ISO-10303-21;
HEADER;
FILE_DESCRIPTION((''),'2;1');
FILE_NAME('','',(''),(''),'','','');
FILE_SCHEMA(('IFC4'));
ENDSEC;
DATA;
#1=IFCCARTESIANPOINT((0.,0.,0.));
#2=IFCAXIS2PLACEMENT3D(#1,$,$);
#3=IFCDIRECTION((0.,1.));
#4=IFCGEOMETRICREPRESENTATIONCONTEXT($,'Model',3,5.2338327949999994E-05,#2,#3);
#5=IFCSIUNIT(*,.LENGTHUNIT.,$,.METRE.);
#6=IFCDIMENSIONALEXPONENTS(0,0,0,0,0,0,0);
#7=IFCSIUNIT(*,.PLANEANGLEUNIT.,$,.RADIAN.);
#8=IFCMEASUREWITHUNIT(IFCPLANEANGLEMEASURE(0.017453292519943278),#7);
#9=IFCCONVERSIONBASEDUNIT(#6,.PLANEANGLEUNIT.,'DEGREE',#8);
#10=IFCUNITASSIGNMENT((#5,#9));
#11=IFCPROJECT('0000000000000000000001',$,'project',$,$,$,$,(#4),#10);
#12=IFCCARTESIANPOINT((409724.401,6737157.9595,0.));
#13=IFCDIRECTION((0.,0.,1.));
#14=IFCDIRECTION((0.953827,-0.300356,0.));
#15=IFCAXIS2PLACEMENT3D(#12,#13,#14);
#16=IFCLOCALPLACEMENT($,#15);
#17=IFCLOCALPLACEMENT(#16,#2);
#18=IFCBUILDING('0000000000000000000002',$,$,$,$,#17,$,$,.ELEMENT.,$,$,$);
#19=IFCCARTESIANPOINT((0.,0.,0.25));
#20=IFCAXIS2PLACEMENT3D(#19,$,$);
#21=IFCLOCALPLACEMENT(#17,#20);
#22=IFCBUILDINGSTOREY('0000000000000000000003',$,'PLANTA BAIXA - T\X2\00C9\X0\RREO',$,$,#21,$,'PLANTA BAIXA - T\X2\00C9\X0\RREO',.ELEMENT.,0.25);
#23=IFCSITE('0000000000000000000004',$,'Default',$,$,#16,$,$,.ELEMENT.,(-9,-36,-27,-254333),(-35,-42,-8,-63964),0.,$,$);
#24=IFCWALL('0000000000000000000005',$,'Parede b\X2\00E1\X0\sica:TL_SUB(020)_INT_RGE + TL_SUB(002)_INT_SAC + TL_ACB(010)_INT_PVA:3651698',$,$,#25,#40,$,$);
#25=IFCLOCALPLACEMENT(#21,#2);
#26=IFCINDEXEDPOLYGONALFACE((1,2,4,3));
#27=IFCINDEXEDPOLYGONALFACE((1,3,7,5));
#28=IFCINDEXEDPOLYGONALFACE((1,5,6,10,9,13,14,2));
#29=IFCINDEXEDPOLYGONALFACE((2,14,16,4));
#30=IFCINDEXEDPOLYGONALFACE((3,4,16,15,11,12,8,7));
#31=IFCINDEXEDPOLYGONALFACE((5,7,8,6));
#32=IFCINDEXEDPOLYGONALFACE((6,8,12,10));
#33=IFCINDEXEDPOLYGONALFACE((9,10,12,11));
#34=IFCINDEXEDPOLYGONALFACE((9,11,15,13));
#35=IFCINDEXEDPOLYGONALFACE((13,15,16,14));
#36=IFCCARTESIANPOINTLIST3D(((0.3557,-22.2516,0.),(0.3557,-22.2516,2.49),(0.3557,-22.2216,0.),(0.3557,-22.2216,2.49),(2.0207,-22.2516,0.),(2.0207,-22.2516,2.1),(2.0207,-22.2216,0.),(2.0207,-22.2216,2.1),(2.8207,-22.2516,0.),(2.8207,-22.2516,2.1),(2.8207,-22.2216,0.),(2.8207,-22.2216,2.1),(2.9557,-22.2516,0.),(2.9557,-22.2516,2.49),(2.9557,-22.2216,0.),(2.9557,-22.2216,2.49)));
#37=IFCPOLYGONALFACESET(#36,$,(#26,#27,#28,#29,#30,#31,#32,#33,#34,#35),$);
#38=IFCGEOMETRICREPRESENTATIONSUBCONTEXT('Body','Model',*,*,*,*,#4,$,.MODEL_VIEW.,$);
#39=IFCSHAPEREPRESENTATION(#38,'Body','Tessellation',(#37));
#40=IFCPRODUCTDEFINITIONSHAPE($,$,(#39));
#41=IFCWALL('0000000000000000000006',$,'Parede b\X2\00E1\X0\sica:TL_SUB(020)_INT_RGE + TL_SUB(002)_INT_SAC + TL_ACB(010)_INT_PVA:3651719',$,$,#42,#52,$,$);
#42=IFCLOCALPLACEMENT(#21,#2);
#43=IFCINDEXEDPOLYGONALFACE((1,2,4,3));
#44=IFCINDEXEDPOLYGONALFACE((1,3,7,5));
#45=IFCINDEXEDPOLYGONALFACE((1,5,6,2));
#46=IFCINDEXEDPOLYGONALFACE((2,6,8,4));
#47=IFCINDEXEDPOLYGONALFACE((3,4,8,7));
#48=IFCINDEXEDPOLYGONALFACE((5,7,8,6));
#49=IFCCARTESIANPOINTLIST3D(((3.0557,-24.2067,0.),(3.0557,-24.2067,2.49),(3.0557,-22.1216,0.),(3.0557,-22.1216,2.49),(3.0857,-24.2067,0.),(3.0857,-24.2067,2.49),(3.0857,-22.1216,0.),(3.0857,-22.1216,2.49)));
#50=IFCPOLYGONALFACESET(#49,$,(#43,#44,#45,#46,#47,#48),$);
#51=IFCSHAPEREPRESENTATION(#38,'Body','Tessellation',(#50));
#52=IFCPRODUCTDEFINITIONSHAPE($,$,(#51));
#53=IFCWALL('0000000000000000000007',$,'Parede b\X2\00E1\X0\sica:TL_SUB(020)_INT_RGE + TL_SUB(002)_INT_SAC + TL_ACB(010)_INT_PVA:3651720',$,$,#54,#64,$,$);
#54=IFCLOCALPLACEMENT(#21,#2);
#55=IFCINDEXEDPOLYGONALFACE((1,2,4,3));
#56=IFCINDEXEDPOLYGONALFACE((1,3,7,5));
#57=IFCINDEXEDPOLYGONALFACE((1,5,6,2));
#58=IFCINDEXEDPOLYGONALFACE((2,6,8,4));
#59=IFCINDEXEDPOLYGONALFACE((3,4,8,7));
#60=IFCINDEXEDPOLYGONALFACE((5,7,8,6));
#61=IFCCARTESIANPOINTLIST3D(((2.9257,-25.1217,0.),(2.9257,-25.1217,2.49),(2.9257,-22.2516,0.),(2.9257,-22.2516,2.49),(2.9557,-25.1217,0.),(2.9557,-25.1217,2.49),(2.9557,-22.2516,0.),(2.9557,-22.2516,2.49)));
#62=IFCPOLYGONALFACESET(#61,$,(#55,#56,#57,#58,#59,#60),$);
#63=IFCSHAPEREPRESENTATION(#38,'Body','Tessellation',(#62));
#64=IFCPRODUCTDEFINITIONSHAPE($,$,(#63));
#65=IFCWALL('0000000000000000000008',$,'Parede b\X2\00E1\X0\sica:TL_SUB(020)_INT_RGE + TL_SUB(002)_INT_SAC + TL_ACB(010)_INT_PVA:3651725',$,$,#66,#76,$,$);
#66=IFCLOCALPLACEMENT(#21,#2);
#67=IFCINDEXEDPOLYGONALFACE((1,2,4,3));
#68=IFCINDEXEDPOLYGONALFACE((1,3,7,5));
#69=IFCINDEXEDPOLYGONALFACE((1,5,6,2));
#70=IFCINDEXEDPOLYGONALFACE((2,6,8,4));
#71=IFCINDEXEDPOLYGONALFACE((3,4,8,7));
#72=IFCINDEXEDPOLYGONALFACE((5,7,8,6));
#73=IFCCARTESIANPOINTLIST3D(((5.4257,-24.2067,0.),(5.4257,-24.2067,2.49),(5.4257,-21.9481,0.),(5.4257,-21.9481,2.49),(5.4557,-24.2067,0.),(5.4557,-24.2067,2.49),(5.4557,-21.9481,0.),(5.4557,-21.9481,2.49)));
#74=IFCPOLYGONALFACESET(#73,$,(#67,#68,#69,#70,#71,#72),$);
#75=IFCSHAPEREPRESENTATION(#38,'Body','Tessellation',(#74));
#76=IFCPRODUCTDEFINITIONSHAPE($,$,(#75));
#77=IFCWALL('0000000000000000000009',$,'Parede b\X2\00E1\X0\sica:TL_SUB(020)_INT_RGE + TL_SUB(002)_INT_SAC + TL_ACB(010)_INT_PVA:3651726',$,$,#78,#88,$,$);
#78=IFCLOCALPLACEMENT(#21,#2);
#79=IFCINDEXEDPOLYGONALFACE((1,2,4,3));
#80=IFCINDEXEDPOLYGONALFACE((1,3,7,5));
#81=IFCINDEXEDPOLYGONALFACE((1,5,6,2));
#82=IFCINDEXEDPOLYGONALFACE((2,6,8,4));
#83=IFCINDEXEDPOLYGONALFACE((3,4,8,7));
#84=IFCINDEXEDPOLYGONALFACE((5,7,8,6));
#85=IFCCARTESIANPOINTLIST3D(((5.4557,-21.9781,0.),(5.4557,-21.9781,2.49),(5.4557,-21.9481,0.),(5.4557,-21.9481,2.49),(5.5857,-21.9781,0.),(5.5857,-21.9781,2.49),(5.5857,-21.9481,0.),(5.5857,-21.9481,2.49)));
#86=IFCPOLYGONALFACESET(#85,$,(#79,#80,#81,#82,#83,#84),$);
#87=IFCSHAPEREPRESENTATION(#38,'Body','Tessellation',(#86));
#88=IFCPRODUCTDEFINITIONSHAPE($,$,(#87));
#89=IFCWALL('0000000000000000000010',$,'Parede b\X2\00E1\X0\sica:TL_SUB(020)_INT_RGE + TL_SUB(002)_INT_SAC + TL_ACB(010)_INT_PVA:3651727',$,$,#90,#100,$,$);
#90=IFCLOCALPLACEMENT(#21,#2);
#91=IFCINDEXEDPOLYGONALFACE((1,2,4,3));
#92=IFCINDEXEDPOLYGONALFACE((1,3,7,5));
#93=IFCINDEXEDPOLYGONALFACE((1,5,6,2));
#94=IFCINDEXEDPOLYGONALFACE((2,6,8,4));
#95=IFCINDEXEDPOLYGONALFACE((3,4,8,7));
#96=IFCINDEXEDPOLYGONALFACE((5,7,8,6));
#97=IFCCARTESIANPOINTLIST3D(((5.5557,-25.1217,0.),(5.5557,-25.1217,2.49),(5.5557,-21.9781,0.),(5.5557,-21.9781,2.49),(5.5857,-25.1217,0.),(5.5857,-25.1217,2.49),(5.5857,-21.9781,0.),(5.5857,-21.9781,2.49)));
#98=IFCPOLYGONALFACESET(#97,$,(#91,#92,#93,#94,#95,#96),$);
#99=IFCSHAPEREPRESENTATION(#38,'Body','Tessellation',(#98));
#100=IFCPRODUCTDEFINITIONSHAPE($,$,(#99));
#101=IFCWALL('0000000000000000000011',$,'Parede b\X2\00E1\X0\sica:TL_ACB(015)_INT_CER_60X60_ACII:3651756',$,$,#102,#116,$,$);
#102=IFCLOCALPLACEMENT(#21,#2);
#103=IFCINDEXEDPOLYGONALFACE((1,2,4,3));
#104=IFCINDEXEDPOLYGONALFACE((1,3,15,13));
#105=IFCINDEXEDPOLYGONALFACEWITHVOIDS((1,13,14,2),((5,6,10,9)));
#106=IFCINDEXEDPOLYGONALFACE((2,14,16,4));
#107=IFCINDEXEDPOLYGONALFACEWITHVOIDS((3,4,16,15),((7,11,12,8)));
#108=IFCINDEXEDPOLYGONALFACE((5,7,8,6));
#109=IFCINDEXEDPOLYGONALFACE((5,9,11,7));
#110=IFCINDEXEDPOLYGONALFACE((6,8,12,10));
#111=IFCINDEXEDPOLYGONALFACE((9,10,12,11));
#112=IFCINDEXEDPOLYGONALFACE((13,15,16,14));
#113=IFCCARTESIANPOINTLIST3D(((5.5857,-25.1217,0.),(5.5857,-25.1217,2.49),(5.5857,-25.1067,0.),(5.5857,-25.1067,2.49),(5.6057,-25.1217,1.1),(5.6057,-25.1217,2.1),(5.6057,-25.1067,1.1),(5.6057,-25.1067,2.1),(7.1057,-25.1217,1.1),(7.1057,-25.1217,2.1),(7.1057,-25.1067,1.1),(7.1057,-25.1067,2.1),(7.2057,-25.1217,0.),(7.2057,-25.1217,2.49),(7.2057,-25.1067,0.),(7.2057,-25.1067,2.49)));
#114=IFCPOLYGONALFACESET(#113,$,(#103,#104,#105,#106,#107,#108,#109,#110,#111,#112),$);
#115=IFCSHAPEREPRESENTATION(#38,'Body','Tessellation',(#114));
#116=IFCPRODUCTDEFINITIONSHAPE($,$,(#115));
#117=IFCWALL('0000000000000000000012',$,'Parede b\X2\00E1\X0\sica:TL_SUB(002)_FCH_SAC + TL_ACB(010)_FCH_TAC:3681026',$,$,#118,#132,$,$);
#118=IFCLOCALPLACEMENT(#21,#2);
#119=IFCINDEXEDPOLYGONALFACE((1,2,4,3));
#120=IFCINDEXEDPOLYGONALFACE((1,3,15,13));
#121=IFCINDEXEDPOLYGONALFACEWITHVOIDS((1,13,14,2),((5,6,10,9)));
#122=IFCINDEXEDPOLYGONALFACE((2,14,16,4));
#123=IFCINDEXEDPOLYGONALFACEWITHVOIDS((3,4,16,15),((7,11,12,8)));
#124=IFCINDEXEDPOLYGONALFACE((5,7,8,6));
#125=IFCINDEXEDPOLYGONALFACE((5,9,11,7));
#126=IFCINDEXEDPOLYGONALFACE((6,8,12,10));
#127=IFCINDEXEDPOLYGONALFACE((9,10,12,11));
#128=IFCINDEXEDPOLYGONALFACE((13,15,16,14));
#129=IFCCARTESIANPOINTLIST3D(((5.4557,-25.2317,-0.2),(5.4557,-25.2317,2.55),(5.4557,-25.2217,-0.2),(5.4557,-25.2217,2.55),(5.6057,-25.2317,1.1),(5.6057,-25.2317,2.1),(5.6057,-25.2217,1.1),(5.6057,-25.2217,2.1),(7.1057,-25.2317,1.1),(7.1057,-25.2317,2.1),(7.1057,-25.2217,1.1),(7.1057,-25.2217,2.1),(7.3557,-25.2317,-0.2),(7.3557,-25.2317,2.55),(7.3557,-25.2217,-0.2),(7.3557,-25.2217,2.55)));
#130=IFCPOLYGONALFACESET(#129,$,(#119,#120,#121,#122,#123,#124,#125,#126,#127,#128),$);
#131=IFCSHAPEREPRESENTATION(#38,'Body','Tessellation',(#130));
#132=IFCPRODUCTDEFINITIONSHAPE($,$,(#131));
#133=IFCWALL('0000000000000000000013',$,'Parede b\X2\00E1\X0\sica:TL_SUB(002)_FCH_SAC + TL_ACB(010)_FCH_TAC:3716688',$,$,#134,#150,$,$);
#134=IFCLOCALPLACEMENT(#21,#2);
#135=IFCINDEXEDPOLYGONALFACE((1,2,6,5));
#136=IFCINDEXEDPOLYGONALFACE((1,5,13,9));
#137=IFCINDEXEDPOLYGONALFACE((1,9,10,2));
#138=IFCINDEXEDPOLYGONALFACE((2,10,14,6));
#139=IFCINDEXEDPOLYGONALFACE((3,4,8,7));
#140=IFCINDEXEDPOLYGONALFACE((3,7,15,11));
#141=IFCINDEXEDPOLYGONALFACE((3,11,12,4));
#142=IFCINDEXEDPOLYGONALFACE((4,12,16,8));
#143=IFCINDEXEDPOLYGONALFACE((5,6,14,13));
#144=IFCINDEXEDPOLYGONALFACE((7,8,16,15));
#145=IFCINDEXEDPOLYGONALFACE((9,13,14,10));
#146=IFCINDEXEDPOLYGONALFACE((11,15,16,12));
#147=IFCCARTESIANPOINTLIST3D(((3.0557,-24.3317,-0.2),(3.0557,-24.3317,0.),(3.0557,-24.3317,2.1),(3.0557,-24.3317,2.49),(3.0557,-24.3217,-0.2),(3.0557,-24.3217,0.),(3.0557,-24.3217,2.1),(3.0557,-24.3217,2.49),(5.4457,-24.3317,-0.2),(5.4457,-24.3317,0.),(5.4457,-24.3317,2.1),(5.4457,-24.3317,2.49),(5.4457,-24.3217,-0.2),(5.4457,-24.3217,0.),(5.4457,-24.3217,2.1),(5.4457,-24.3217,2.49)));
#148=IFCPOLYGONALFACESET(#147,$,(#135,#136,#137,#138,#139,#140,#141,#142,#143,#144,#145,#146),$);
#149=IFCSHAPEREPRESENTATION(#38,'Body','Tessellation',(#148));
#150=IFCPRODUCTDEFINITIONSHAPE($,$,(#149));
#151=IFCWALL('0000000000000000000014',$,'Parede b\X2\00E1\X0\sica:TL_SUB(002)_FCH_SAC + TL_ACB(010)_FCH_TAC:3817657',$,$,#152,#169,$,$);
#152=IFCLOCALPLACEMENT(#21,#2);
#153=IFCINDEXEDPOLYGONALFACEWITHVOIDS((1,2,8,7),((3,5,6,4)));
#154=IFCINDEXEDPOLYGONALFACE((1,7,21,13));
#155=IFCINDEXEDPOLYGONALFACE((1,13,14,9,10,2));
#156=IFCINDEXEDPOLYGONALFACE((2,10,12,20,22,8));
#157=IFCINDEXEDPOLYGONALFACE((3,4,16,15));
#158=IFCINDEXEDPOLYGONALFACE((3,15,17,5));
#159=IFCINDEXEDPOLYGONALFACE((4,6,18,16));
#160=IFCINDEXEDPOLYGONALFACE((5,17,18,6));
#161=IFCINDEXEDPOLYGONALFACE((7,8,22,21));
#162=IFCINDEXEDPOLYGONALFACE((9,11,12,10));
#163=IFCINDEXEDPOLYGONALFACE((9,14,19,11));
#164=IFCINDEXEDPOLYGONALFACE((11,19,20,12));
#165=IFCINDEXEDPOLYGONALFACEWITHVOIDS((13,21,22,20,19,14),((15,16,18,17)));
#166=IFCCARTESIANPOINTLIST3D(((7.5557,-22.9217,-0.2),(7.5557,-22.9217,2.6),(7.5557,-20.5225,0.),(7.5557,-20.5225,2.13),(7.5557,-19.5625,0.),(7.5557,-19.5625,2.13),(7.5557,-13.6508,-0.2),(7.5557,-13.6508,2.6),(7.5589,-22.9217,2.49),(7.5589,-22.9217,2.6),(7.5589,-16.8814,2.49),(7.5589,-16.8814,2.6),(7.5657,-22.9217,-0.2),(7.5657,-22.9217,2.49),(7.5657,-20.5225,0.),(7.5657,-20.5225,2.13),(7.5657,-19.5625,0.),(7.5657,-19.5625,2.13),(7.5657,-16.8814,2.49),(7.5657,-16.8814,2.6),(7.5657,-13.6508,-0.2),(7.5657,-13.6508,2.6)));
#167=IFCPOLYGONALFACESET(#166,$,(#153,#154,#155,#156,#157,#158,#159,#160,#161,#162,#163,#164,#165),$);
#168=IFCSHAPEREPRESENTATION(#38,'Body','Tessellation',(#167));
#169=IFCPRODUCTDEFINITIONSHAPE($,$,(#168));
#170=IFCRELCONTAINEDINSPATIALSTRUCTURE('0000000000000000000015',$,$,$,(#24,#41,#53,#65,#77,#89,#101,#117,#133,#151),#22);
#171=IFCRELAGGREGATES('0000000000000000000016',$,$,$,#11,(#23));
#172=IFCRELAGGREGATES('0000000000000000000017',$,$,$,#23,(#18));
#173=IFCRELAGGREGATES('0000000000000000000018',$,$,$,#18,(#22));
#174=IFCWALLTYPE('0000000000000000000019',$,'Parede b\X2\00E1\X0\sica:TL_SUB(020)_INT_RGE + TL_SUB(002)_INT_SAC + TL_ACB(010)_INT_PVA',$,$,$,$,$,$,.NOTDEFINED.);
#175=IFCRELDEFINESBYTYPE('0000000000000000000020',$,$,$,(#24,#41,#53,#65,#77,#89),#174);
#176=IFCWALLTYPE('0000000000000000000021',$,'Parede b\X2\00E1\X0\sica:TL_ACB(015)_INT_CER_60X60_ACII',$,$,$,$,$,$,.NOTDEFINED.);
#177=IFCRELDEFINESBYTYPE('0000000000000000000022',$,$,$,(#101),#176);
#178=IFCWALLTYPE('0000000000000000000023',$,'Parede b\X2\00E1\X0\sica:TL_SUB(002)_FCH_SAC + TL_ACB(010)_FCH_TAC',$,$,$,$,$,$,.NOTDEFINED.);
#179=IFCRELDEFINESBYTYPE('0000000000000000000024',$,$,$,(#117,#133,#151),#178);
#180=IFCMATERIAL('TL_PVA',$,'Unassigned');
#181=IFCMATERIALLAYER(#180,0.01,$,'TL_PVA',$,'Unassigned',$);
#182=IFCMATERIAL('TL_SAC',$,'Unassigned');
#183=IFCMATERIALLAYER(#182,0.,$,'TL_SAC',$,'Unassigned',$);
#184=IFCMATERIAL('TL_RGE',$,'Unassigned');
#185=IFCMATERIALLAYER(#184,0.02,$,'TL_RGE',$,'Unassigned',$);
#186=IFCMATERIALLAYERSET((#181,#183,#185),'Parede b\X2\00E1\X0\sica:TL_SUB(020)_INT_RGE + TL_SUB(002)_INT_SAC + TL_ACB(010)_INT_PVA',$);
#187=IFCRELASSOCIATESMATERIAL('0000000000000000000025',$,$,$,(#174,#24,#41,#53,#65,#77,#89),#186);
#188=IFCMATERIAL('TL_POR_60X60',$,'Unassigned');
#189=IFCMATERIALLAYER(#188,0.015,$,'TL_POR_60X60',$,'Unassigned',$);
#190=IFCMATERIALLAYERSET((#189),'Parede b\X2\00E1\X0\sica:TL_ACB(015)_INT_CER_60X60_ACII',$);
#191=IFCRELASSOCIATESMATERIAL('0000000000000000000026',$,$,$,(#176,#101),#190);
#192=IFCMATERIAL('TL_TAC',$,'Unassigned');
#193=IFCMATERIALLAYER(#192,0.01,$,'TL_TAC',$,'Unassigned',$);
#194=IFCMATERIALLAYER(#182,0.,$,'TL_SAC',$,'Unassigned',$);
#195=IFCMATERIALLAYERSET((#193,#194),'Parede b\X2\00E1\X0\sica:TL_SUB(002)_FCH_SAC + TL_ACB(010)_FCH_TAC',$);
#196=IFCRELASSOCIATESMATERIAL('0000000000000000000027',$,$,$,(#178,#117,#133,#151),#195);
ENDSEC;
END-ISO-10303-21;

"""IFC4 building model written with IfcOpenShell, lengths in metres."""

from ifc_helpers import new_model, entity, si_unit, converted_unit, direction, frame, frame_2d, origin, place, context, subcontext, project, spatial, polyline, rectangle, extrude, clip, bounded_halfspace, material, layer, layer_set, layer_usage, type_object, element, save


model = new_model("IFC4")

# Units and contexts
model_context = context("Model", 3, precision=5.2338327949999994e-05, world=origin(), true_north=direction((0.0, 1.0)))
body_context = subcontext(model_context, "Body", "Model", "MODEL_VIEW")
ifc_project = project(units=[si_unit("LENGTHUNIT", "METRE"), converted_unit("PLANEANGLEUNIT", "DEGREE", entity("IfcPlaneAngleMeasure", 0.017453292519943278), si_unit("PLANEANGLEUNIT", "RADIAN"), dimensions=[0, 0, 0, 0, 0, 0, 0])], contexts=[model_context])

# Site, building, storey
site_placement = place(None, frame((409724.401, 6737157.9595, 0.0), z_axis=(0.0, 0.0, 1.0), x_axis=(0.953827, -0.300356, 0.0)))
site = spatial("IfcSite", under=ifc_project, at=site_placement, Name="Default", CompositionType="ELEMENT", RefLatitude=(-9, -36, -27, -254333), RefLongitude=(-35, -42, -8, -63964), RefElevation=0.0)
building_placement = place(site_placement, origin())
building = spatial("IfcBuilding", under=site, at=building_placement, CompositionType="ELEMENT")
storey_placement = place(building_placement, frame((0.0, 0.0, 0.25)))
storey = spatial("IfcBuildingStorey", under=building, at=storey_placement, Name="PLANTA BAIXA - TÉRREO", LongName="PLANTA BAIXA - TÉRREO", CompositionType="ELEMENT", Elevation=0.25)

# Wall, opening
ifc_material_1 = material(Name="TL_PVA", Category="Unassigned")
ifc_layer_1 = layer(ifc_material_1, 0.01, Name="TL_PVA", Category="Unassigned")
ifc_material_2 = material(Name="TL_SAC", Category="Unassigned")
ifc_layer_2 = layer(ifc_material_2, 0.0, Name="TL_SAC", Category="Unassigned")
ifc_material_3 = material(Name="TL_RGE", Category="Unassigned")
ifc_layer_3 = layer(ifc_material_3, 0.02, Name="TL_RGE", Category="Unassigned")
ifc_layer_set_1 = layer_set([ifc_layer_1, ifc_layer_2, ifc_layer_3], Name="Parede básica:TL_SUB(020)_INT_RGE + TL_SUB(002)_INT_SAC + TL_ACB(010)_INT_PVA")
ifc_layer_usage_1 = layer_usage(ifc_layer_set_1, "AXIS2", "NEGATIVE", 0.015)
wall_type_1 = type_object("IfcWallType", Name="Parede básica:TL_SUB(020)_INT_RGE + TL_SUB(002)_INT_SAC + TL_ACB(010)_INT_PVA", PredefinedType="NOTDEFINED", material=ifc_layer_set_1)
wall_1_placement = place(storey_placement, frame((2.9557, -22.2366, 0.0), z_axis=(0.0, 0.0, 1.0), x_axis=(-1.0, 0.0, 0.0)))
wall_1 = element("IfcWall", 1, at=wall_1_placement, inside=storey, type_object=wall_type_1, material=ifc_layer_usage_1, Name="Parede básica:TL_SUB(020)_INT_RGE + TL_SUB(002)_INT_SAC + TL_ACB(010)_INT_PVA:3651698", context=body_context, shape_type="SweptSolid", body=[
    extrude(rectangle(XDim=2.6, YDim=0.03, at=frame_2d((1.3, 0.0), x_axis=(1.0, 0.0))), origin(), (0.0, 0.0, 1.0), 2.49),
])
opening_1_placement = place(wall_1_placement, frame((2.9557, -22.2366, 0.0)))
element("IfcOpeningElement", 2, at=opening_1_placement, cuts=wall_1, PredefinedType="OPENING", context=body_context, shape_type="SweptSolid", body=[
    extrude(rectangle(XDim=2.1, YDim=0.8, at=frame_2d((0.0, 0.0), x_axis=(1.0, 0.0))), frame((-2.4207, 20.5976, 1.05), z_axis=(0.0, 1.0, 0.0), x_axis=(0.0, 0.0, 1.0)), (0.0, 0.0, 1.0), 3.048),
])

# Walls
ifc_layer_usage_2 = layer_usage(ifc_layer_set_1, "AXIS2", "POSITIVE", -0.015)
wall_2_placement = place(storey_placement, frame((3.0707, -24.2067, 0.0), z_axis=(0.0, 0.0, 1.0), x_axis=(0.0, 1.0, 0.0)))
element("IfcWall", 3, at=wall_2_placement, inside=storey, type_object=wall_type_1, material=ifc_layer_usage_2, Name="Parede básica:TL_SUB(020)_INT_RGE + TL_SUB(002)_INT_SAC + TL_ACB(010)_INT_PVA:3651719", context=body_context, shape_type="SweptSolid", body=[
    extrude(rectangle(XDim=2.0851, YDim=0.03, at=frame_2d((1.0426, 0.0), x_axis=(-1.0, 0.0))), origin(), (0.0, 0.0, 1.0), 2.49),
])
ifc_layer_usage_3 = layer_usage(ifc_layer_set_1, "AXIS2", "POSITIVE", -0.015)
wall_3_placement = place(storey_placement, frame((2.9407, -22.2516, 0.0), z_axis=(0.0, 0.0, 1.0), x_axis=(0.0, -1.0, 0.0)))
element("IfcWall", 4, at=wall_3_placement, inside=storey, type_object=wall_type_1, material=ifc_layer_usage_3, Name="Parede básica:TL_SUB(020)_INT_RGE + TL_SUB(002)_INT_SAC + TL_ACB(010)_INT_PVA:3651720", context=body_context, shape_type="SweptSolid", body=[
    extrude(rectangle(XDim=2.8701, YDim=0.03, at=frame_2d((1.4351, 0.0), x_axis=(-1.0, 0.0))), origin(), (0.0, 0.0, 1.0), 2.49),
])
ifc_layer_usage_4 = layer_usage(ifc_layer_set_1, "AXIS2", "POSITIVE", -0.015)
wall_4_placement = place(storey_placement, frame((5.4407, -21.9481, 0.0), z_axis=(0.0, 0.0, 1.0), x_axis=(0.0, -1.0, 0.0)))
element("IfcWall", 5, at=wall_4_placement, inside=storey, type_object=wall_type_1, material=ifc_layer_usage_4, Name="Parede básica:TL_SUB(020)_INT_RGE + TL_SUB(002)_INT_SAC + TL_ACB(010)_INT_PVA:3651725", context=body_context, shape_type="SweptSolid", body=[
    extrude(rectangle(XDim=2.2587, YDim=0.03, at=frame_2d((1.1293, 0.0), x_axis=(-1.0, 0.0))), origin(), (0.0, 0.0, 1.0), 2.49),
])
ifc_layer_usage_5 = layer_usage(ifc_layer_set_1, "AXIS2", "POSITIVE", -0.015)
wall_5_placement = place(storey_placement, frame((5.5857, -21.9631, 0.0), z_axis=(0.0, 0.0, 1.0), x_axis=(-1.0, 0.0, 0.0)))
element("IfcWall", 6, at=wall_5_placement, inside=storey, type_object=wall_type_1, material=ifc_layer_usage_5, Name="Parede básica:TL_SUB(020)_INT_RGE + TL_SUB(002)_INT_SAC + TL_ACB(010)_INT_PVA:3651726", context=body_context, shape_type="SweptSolid", body=[
    extrude(rectangle(XDim=0.13, YDim=0.03, at=frame_2d((0.065, 0.0), x_axis=(-1.0, 0.0))), origin(), (0.0, 0.0, 1.0), 2.49),
])
ifc_layer_usage_6 = layer_usage(ifc_layer_set_1, "AXIS2", "POSITIVE", -0.015)
wall_6_placement = place(storey_placement, frame((5.5707, -25.1217, 0.0), z_axis=(0.0, 0.0, 1.0), x_axis=(0.0, 1.0, 0.0)))
element("IfcWall", 7, at=wall_6_placement, inside=storey, type_object=wall_type_1, material=ifc_layer_usage_6, Name="Parede básica:TL_SUB(020)_INT_RGE + TL_SUB(002)_INT_SAC + TL_ACB(010)_INT_PVA:3651727", context=body_context, shape_type="SweptSolid", body=[
    extrude(rectangle(XDim=3.1437, YDim=0.03, at=frame_2d((1.5718, 0.0), x_axis=(-1.0, 0.0))), origin(), (0.0, 0.0, 1.0), 2.49),
])

# Walls, openings
ifc_material_4 = material(Name="TL_POR_60X60", Category="Unassigned")
ifc_layer_4 = layer(ifc_material_4, 0.015, Name="TL_POR_60X60", Category="Unassigned")
ifc_layer_set_2 = layer_set([ifc_layer_4], Name="Parede básica:TL_ACB(015)_INT_CER_60X60_ACII")
ifc_layer_usage_7 = layer_usage(ifc_layer_set_2, "AXIS2", "POSITIVE", -0.0075)
wall_type_2 = type_object("IfcWallType", Name="Parede básica:TL_ACB(015)_INT_CER_60X60_ACII", PredefinedType="NOTDEFINED", material=ifc_layer_set_2)
wall_7_placement = place(storey_placement, frame((7.2057, -25.1142, 0.0), z_axis=(0.0, 0.0, 1.0), x_axis=(-1.0, 0.0, 0.0)))
wall_7 = element("IfcWall", 8, at=wall_7_placement, inside=storey, type_object=wall_type_2, material=ifc_layer_usage_7, Name="Parede básica:TL_ACB(015)_INT_CER_60X60_ACII:3651756", context=body_context, shape_type="SweptSolid", body=[
    extrude(rectangle(XDim=1.62, YDim=0.015, at=frame_2d((0.81, 0.0), x_axis=(-1.0, 0.0))), origin(), (0.0, 0.0, 1.0), 2.49),
])
opening_2_placement = place(wall_7_placement, frame((7.2057, -25.1142, 1.1)))
element("IfcOpeningElement", 9, at=opening_2_placement, cuts=wall_7, PredefinedType="OPENING", context=body_context, shape_type="SweptSolid", body=[
    extrude(rectangle(XDim=1.0, YDim=1.5, at=frame_2d((0.0, 0.0), x_axis=(0.0, 1.0))), frame((-6.3557, 23.5977, 0.5), z_axis=(0.0, 1.0, 0.0), x_axis=(1.0, 0.0, 0.0)), (0.0, 0.0, 1.0), 3.048),
])
ifc_material_5 = material(Name="TL_TAC", Category="Unassigned")
ifc_layer_5 = layer(ifc_material_5, 0.01, Name="TL_TAC", Category="Unassigned")
ifc_layer_6 = layer(ifc_material_2, 0.0, Name="TL_SAC", Category="Unassigned")
ifc_layer_set_3 = layer_set([ifc_layer_5, ifc_layer_6], Name="Parede básica:TL_SUB(002)_FCH_SAC + TL_ACB(010)_FCH_TAC")
ifc_layer_usage_8 = layer_usage(ifc_layer_set_3, "AXIS2", "POSITIVE", -0.005)
wall_type_3 = type_object("IfcWallType", Name="Parede básica:TL_SUB(002)_FCH_SAC + TL_ACB(010)_FCH_TAC", PredefinedType="NOTDEFINED", material=ifc_layer_set_3)
wall_8_placement = place(storey_placement, frame((7.3557, -25.2267, -0.2), z_axis=(0.0, 0.0, 1.0), x_axis=(-1.0, 0.0, 0.0)))
wall_8 = element("IfcWall", 10, at=wall_8_placement, inside=storey, type_object=wall_type_3, material=ifc_layer_usage_8, Name="Parede básica:TL_SUB(002)_FCH_SAC + TL_ACB(010)_FCH_TAC:3681026", context=body_context, shape_type="SweptSolid", body=[
    extrude(rectangle(XDim=1.9, YDim=0.01, at=frame_2d((0.95, 0.0), x_axis=(-1.0, 0.0))), origin(), (0.0, 0.0, 1.0), 2.75),
])
opening_3_placement = place(wall_8_placement, frame((7.3557, -25.2267, 1.3)))
element("IfcOpeningElement", 11, at=opening_3_placement, cuts=wall_8, PredefinedType="OPENING", context=body_context, shape_type="SweptSolid", body=[
    extrude(rectangle(XDim=1.0, YDim=1.5, at=frame_2d((0.0, 0.0), x_axis=(0.0, 1.0))), frame((-6.3557, 23.5977, 0.5), z_axis=(0.0, 1.0, 0.0), x_axis=(1.0, 0.0, 0.0)), (0.0, 0.0, 1.0), 3.048),
])
ifc_layer_usage_9 = layer_usage(ifc_layer_set_3, "AXIS2", "NEGATIVE", 0.005)
wall_9_placement = place(storey_placement, frame((5.4457, -24.3267, -0.2), z_axis=(0.0, 0.0, 1.0), x_axis=(-1.0, 0.0, 0.0)))
wall_9 = element("IfcWall", 12, at=wall_9_placement, inside=storey, type_object=wall_type_3, material=ifc_layer_usage_9, Name="Parede básica:TL_SUB(002)_FCH_SAC + TL_ACB(010)_FCH_TAC:3716688", context=body_context, shape_type="SweptSolid", body=[
    extrude(rectangle(XDim=2.39, YDim=0.01, at=frame_2d((1.195, 0.0), x_axis=(-1.0, 0.0))), origin(), (0.0, 0.0, 1.0), 2.69),
])
opening_4_placement = place(wall_9_placement, frame((5.4457, -24.3267, 0.2)))
element("IfcOpeningElement", 13, at=opening_4_placement, cuts=wall_9, PredefinedType="OPENING", context=body_context, shape_type="SweptSolid", body=[
    extrude(rectangle(XDim=2.1, YDim=2.4, at=frame_2d((0.0, 0.0), x_axis=(0.0, 1.0))), frame((-4.2557, 22.7977, 1.05), z_axis=(0.0, 1.0, 0.0), x_axis=(-1.0, 0.0, 0.0)), (0.0, 0.0, 1.0), 3.048),
])
ifc_layer_usage_10 = layer_usage(ifc_layer_set_3, "AXIS2", "NEGATIVE", 0.005)
wall_10_placement = place(storey_placement, frame((7.5607, -22.9217, -0.2), z_axis=(0.0, 0.0, 1.0), x_axis=(0.0, 1.0, 0.0)))
wall_10 = element("IfcWall", 14, at=wall_10_placement, inside=storey, type_object=wall_type_3, material=ifc_layer_usage_10, Name="Parede básica:TL_SUB(002)_FCH_SAC + TL_ACB(010)_FCH_TAC:3817657", context=body_context, shape_type="Clipping", body=[
    clip(extrude(rectangle(XDim=9.2709, YDim=0.01, at=frame_2d((4.6355, 0.0), x_axis=(-1.0, 0.0))), origin(), (0.0, 0.0, 1.0), 2.8), bounded_halfspace(frame((0.0, -0.005, 2.69), z_axis=(0.0, 0.0, -1.0), x_axis=(-1.0, 0.0, 0.0)), True, frame((0.0, -0.005, 2.69)), polyline([(0.0, 0.0), (0.01, 0.0), (6.0403, 0.0), (6.0403, 0.0068), (0.0, 0.0068), (0.0, 0.0)]))),
])
opening_5_placement = place(wall_10_placement, frame((22.9217, 7.5607, 0.2)))
element("IfcOpeningElement", 15, at=opening_5_placement, cuts=wall_10, PredefinedType="OPENING", context=body_context, shape_type="SweptSolid", body=[
    extrude(rectangle(XDim=2.13, YDim=0.96, at=frame_2d((0.0, 0.0), x_axis=(1.0, 0.0))), frame((-20.0425, -8.8797, 1.065), z_axis=(0.0, 1.0, 0.0), x_axis=(0.0, 0.0, 1.0)), (0.0, 0.0, 1.0), 3.048),
])

save(model, "model.ifc")
